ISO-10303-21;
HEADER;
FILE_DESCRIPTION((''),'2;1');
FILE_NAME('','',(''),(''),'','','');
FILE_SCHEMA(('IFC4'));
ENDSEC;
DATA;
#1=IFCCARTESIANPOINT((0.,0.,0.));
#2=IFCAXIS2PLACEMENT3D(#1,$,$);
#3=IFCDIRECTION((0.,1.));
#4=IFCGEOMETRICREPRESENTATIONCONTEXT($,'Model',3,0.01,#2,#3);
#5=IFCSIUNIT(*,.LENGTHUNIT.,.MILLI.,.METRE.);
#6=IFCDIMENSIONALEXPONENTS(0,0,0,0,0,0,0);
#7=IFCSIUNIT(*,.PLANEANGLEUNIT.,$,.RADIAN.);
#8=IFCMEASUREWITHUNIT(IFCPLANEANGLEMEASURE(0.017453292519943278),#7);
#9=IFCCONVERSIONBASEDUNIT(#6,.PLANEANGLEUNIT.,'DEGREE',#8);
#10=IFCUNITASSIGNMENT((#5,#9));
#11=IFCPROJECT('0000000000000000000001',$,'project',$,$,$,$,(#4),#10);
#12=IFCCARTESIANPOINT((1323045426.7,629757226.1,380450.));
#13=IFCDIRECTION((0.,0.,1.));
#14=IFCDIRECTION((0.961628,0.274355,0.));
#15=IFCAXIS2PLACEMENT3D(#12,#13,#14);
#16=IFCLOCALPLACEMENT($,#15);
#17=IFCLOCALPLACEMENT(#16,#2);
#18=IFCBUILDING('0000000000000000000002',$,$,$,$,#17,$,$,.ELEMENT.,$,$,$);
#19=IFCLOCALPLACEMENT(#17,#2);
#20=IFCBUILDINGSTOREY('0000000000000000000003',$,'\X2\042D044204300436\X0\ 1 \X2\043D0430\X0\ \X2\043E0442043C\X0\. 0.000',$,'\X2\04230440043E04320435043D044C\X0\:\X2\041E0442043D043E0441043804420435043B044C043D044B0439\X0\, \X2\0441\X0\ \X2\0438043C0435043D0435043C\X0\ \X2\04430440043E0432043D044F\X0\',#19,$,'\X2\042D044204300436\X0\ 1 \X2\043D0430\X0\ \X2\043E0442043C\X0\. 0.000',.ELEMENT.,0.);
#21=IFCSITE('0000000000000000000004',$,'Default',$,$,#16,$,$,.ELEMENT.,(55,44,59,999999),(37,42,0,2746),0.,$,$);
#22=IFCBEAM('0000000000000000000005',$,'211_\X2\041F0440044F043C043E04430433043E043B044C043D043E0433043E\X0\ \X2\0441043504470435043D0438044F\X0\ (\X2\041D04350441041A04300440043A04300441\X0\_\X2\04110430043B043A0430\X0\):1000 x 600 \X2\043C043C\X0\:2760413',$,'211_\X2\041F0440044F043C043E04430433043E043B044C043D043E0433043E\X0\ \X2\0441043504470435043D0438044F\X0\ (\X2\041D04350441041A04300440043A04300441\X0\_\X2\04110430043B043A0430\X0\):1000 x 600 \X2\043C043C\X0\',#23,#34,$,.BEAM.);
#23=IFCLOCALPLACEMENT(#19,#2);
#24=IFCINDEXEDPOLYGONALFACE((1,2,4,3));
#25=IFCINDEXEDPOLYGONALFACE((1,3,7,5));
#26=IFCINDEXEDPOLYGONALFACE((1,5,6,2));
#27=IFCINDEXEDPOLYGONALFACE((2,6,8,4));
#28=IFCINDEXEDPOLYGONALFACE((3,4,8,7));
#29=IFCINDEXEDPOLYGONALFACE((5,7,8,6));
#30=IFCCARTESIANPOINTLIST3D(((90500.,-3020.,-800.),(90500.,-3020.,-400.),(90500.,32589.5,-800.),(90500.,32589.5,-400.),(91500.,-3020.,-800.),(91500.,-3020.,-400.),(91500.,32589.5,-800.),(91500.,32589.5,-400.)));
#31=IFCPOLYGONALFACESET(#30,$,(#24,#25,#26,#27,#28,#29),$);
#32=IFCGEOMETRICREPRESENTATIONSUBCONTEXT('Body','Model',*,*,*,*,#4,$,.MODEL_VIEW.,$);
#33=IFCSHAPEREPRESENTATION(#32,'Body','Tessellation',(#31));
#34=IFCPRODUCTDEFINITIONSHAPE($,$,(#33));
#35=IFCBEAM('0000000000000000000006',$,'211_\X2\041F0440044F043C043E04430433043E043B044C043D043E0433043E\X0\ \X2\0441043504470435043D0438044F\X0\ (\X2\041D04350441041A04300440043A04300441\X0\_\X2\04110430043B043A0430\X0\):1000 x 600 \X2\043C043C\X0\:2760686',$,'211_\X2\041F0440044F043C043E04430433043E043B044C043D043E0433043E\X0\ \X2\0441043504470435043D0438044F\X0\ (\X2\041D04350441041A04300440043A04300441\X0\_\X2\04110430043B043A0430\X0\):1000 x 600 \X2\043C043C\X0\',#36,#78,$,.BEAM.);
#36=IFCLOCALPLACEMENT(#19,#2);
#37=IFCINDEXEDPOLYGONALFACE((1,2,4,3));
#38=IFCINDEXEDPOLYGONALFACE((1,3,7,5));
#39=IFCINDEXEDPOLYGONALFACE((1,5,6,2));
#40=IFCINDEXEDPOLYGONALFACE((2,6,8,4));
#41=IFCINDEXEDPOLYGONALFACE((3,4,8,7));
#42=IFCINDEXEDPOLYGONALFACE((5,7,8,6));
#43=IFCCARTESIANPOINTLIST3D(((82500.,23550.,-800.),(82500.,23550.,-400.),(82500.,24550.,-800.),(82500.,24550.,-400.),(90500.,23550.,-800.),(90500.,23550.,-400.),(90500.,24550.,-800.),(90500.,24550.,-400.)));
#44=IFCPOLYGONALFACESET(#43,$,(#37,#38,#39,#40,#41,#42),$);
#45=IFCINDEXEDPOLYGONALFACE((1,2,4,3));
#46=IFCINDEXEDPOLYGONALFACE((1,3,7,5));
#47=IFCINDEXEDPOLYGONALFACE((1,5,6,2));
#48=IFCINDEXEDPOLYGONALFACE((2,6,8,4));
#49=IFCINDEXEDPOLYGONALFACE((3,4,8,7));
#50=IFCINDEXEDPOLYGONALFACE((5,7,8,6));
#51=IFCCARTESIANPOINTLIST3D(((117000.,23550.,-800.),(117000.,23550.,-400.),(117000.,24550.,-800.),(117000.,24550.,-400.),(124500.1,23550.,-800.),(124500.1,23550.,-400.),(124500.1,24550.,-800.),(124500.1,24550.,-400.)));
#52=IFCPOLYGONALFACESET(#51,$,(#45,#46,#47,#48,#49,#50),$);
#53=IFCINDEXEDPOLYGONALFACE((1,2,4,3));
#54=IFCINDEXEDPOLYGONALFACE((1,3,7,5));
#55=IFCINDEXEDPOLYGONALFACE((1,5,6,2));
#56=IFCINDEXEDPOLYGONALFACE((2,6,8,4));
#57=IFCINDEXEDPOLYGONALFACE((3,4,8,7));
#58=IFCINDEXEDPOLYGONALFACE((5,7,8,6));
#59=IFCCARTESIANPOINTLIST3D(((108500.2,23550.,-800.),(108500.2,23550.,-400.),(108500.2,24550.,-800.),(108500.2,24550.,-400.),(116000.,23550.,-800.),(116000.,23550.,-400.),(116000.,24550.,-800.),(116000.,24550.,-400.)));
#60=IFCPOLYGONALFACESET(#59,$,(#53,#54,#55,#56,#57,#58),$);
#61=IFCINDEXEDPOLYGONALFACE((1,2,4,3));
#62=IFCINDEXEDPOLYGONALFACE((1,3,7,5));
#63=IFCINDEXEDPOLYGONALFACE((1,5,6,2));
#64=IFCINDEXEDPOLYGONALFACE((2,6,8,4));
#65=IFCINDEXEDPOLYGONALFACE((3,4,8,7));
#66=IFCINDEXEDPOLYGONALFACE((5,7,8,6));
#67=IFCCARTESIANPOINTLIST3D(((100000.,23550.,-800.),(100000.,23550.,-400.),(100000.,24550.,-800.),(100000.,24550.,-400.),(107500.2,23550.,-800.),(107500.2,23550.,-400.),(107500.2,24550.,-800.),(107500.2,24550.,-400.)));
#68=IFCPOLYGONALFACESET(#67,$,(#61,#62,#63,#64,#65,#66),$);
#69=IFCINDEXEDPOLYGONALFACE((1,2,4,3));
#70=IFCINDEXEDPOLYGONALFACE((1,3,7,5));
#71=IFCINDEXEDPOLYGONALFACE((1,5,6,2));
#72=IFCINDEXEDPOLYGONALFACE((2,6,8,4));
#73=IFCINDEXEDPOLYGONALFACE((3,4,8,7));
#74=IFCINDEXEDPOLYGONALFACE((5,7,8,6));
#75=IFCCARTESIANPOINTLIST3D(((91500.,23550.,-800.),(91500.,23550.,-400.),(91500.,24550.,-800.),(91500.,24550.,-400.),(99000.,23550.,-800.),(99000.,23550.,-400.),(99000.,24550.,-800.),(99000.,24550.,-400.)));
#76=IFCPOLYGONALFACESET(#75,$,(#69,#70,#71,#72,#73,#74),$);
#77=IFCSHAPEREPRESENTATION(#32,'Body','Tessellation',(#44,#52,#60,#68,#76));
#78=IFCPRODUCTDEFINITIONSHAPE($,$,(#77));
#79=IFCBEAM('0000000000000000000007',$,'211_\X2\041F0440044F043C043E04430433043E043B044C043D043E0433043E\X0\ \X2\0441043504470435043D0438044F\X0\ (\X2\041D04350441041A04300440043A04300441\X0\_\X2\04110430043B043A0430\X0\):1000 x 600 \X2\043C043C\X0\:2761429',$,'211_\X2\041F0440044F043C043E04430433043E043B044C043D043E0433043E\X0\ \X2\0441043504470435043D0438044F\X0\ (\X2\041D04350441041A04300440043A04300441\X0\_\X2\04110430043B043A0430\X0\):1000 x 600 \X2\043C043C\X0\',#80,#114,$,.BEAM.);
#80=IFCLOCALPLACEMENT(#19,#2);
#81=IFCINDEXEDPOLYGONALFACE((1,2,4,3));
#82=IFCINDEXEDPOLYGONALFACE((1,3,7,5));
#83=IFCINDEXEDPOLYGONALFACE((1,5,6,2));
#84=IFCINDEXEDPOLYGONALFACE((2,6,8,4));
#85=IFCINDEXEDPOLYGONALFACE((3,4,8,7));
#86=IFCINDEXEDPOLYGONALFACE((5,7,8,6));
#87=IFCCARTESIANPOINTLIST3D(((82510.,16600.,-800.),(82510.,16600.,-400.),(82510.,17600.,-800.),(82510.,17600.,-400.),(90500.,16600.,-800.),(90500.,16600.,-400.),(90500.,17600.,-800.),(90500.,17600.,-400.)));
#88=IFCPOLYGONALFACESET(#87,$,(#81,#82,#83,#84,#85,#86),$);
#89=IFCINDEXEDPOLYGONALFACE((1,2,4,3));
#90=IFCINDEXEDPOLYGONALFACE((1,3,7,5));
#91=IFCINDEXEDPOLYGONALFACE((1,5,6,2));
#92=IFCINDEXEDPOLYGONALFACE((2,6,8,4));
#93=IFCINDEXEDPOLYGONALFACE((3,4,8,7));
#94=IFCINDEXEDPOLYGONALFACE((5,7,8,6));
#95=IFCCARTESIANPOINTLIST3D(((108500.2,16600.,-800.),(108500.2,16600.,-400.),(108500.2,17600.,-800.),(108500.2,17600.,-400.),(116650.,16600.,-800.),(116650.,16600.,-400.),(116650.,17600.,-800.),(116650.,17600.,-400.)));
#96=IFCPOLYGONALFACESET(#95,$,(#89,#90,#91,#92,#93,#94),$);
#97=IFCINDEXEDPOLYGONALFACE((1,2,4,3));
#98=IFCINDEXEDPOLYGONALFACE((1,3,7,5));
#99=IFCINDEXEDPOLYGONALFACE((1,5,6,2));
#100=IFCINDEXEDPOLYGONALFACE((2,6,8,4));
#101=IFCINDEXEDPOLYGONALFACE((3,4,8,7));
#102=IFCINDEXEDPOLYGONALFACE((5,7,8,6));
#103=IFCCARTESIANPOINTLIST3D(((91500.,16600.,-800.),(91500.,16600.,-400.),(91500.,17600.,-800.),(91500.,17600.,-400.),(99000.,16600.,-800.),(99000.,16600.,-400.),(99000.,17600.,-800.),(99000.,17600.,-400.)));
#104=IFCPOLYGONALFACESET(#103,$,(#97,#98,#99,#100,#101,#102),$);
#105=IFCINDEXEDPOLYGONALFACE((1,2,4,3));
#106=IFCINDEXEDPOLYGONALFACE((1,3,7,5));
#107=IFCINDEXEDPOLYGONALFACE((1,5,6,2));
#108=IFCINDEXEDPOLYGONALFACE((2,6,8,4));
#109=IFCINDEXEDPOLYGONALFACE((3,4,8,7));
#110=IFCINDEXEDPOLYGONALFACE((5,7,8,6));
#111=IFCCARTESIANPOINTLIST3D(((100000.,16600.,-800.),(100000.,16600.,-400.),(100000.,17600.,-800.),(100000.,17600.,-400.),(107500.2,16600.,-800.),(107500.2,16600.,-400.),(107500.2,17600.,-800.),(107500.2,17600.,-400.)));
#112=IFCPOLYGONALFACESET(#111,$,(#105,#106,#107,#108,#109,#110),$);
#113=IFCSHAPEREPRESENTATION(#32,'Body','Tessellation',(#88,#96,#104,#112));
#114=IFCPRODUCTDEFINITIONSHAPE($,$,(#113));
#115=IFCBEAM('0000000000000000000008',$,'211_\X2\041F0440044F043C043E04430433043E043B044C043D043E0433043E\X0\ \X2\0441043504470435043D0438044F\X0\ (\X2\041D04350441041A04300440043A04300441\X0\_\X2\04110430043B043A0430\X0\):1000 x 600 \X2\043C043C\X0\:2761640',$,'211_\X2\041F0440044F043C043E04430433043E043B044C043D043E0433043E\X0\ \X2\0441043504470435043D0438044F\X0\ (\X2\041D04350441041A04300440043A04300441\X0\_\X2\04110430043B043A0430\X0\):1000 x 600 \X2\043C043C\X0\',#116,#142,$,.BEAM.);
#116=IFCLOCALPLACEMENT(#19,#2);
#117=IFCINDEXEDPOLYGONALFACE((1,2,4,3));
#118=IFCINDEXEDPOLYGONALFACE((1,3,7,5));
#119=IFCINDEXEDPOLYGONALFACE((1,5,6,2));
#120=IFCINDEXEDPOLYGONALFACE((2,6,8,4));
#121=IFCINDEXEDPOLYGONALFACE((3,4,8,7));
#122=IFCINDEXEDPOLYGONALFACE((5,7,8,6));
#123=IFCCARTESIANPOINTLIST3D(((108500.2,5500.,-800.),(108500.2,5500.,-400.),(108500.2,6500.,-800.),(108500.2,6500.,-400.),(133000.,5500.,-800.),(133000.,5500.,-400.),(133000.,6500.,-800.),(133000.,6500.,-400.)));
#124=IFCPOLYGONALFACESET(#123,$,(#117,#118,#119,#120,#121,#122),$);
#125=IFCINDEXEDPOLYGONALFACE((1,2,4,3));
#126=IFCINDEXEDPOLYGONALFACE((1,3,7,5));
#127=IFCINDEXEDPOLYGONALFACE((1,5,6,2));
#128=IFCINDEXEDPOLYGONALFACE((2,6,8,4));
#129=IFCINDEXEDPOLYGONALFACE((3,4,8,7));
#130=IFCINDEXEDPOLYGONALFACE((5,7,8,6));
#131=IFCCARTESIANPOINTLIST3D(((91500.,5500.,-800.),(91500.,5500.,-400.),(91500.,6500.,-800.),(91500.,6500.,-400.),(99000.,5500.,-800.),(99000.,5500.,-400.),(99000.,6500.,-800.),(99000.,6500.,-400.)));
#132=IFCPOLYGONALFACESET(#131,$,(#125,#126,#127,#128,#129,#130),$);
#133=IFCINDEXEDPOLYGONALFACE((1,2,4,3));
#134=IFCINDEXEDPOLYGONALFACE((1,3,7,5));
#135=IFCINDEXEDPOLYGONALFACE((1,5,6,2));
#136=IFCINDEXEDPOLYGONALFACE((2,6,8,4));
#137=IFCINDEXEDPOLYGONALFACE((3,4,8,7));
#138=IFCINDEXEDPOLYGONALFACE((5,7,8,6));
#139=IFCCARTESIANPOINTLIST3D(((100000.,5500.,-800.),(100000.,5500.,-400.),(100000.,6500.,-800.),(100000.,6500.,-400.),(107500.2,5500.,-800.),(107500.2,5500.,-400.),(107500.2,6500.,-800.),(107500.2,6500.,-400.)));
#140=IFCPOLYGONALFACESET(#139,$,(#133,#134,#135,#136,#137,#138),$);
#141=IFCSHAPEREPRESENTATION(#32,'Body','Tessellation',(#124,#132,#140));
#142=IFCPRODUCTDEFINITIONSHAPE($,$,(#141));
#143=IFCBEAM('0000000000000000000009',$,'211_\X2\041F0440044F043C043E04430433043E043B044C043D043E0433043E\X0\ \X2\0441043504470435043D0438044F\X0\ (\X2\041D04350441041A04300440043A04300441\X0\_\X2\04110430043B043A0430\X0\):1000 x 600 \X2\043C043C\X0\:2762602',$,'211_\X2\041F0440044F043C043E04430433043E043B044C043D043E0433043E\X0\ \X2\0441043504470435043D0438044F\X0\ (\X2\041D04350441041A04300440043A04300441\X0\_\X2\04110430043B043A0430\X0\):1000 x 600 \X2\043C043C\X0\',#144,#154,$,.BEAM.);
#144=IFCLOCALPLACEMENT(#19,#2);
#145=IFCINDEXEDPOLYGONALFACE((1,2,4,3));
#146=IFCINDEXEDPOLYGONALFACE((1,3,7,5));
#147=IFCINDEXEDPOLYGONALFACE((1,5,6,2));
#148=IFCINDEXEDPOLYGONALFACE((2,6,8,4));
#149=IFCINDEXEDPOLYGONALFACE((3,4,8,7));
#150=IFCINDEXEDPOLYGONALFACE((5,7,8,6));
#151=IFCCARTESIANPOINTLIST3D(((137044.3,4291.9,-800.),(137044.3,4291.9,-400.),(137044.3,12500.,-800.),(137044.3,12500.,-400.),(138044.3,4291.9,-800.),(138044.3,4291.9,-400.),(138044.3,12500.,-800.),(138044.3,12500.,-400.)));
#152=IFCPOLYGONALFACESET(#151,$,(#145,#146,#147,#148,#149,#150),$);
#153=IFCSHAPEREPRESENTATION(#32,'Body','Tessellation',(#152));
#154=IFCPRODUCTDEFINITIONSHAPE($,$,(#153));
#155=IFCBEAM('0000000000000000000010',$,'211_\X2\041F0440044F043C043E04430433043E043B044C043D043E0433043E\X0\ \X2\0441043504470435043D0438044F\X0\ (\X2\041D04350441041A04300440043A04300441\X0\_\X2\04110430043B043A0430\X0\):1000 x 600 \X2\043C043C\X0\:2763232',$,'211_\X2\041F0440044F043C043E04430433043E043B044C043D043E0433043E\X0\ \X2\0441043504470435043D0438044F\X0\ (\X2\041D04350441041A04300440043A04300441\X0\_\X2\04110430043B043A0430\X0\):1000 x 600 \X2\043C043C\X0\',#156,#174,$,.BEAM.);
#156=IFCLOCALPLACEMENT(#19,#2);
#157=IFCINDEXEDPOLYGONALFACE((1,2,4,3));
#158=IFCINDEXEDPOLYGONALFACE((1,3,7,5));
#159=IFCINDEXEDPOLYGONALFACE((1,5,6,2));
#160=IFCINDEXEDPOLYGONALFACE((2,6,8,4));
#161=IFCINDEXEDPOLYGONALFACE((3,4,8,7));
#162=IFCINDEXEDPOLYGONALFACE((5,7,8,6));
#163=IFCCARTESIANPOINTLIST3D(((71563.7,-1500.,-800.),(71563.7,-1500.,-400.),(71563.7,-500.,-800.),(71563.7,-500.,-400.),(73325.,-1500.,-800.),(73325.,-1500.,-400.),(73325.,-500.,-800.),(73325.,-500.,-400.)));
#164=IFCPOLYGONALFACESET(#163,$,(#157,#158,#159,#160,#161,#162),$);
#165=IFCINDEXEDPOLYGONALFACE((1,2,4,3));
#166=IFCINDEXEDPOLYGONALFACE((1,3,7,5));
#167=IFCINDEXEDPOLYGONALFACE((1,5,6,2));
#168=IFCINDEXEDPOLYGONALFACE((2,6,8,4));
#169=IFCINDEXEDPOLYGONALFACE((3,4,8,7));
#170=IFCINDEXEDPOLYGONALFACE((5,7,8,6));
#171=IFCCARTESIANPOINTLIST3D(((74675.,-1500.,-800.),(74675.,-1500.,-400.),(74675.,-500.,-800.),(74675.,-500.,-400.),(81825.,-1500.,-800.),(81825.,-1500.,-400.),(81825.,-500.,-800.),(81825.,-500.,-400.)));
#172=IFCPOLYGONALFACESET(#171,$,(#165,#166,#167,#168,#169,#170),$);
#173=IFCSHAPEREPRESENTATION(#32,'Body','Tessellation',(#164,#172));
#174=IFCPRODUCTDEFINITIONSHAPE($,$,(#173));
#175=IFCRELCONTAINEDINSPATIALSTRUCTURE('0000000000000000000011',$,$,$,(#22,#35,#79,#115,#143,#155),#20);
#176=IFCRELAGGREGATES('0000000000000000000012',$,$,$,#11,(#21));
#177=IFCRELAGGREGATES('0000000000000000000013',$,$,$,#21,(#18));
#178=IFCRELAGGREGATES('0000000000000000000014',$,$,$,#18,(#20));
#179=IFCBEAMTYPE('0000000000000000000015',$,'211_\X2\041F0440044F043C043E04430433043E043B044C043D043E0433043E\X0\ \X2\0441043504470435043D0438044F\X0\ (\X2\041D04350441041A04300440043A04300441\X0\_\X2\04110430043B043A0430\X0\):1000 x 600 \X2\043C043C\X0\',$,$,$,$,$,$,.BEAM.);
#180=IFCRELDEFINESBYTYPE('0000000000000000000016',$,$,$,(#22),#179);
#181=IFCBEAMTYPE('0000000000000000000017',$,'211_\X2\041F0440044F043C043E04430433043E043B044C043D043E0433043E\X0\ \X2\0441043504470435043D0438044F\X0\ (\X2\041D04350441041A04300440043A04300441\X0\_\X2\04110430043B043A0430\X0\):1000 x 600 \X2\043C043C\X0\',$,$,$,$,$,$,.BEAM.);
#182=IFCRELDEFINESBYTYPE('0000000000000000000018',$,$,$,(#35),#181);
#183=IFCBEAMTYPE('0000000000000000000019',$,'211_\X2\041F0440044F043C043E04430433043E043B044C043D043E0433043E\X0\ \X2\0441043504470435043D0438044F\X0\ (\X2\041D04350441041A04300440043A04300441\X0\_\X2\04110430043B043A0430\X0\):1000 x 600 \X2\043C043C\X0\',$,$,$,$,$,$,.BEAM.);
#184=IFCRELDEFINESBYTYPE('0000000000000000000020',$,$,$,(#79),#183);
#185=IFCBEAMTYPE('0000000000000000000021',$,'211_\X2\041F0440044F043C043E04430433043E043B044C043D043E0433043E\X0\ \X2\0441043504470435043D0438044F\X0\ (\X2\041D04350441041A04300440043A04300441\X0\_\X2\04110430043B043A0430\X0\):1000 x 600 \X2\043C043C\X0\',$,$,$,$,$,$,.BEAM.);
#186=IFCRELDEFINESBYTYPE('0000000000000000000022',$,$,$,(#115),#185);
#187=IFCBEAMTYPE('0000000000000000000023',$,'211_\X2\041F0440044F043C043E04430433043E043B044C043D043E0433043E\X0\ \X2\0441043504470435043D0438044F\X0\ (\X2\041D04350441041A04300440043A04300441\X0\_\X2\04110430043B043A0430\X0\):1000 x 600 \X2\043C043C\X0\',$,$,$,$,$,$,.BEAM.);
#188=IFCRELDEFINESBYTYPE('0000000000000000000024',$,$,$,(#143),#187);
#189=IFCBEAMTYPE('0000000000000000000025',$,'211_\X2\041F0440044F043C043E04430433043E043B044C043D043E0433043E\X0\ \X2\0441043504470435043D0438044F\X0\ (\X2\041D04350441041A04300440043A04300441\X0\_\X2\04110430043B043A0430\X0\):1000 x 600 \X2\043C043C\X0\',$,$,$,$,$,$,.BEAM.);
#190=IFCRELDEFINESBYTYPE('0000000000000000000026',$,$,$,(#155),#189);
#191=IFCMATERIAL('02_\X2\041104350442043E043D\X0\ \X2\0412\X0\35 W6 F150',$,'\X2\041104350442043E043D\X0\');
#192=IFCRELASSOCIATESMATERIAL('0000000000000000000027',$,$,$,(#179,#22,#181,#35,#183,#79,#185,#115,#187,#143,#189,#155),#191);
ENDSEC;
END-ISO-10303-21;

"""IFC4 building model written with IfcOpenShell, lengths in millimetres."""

from ifc_helpers import new_model, entity, si_unit, converted_unit, direction, frame, origin, place, context, subcontext, project, spatial, indexed_curve, outline, extrude, source, transform, mapped, material, type_object, type_shapes, element, save


model = new_model("IFC4")

# Units and contexts
model_context = context("Model", 3, precision=0.01, world=origin(), true_north=direction((0.0, 1.0)))
body_context = subcontext(model_context, "Body", "Model", "MODEL_VIEW")
ifc_project = project(units=[si_unit("LENGTHUNIT", "METRE", prefix="MILLI"), converted_unit("PLANEANGLEUNIT", "DEGREE", entity("IfcPlaneAngleMeasure", 0.017453292519943278), si_unit("PLANEANGLEUNIT", "RADIAN"), dimensions=[0, 0, 0, 0, 0, 0, 0])], contexts=[model_context])

# Site, building, storey
site_placement = place(None, frame((1323045426.7, 629757226.1, 380450.0), z_axis=(0.0, 0.0, 1.0), x_axis=(0.961628, 0.274355, 0.0)))
site = spatial("IfcSite", under=ifc_project, at=site_placement, Name="Default", CompositionType="ELEMENT", RefLatitude=(55, 44, 59, 999999), RefLongitude=(37, 42, 0, 2746), RefElevation=0.0)
building_placement = place(site_placement, origin())
building = spatial("IfcBuilding", under=site, at=building_placement, CompositionType="ELEMENT")
storey_placement = place(building_placement, origin())
storey = spatial("IfcBuildingStorey", under=building, at=storey_placement, Name="Этаж 1 на отм. 0.000", ObjectType="Уровень:Относительный, с именем уровня", LongName="Этаж 1 на отм. 0.000", CompositionType="ELEMENT", Elevation=0.0)

# Beams
ifc_material = material(Name="02_Бетон В35 W6 F150", Category="Бетон")
beam_type_1 = type_object("IfcBeamType", Name="211_Прямоугольного сечения (НесКаркас_Балка):1000 x 600 мм", PredefinedType="BEAM", material=ifc_material)
shared_shape_1 = source(origin(), body_context, "Body", "SweptSolid", [
    extrude(outline(indexed_curve([(-500.0, -200.0), (500.0, -200.0), (500.0, 200.0), (-500.0, 200.0), (-500.0, -200.0)], self_intersect=False)), frame((91000.0, 32589.5, -600.0), z_axis=(0.0, -1.0, 0.0), x_axis=(-1.0, 0.0, 0.0)), (0.0, 0.0, 1.0), 35609.5),
])
type_shapes(beam_type_1, [shared_shape_1])
beam_1_placement = place(storey_placement, origin())
element("IfcBeam", 1, at=beam_1_placement, inside=storey, type_object=beam_type_1, material=ifc_material, Name="211_Прямоугольного сечения (НесКаркас_Балка):1000 x 600 мм:2760413", ObjectType="211_Прямоугольного сечения (НесКаркас_Балка):1000 x 600 мм", PredefinedType="BEAM", context=body_context, shape_type="MappedRepresentation", body=[
    mapped(shared_shape_1, transform((0.0, 0.0, 0.0), scale=1.0)),
])
beam_type_2 = type_object("IfcBeamType", Name="211_Прямоугольного сечения (НесКаркас_Балка):1000 x 600 мм", PredefinedType="BEAM", material=ifc_material)
shared_shape_2 = source(origin(), body_context, "Body", "SweptSolid", [
    extrude(outline(indexed_curve([(-200.0, -500.0), (200.0, -500.0), (200.0, 500.0), (-200.0, 500.0), (-200.0, -500.0)], self_intersect=False)), frame((82500.0, 24050.0, -600.0), z_axis=(1.0, 0.0, 0.0), x_axis=(0.0, 0.0, -1.0)), (0.0, 0.0, 1.0), 8000.0),
    extrude(outline(indexed_curve([(-200.0, -500.0), (200.0, -500.0), (200.0, 500.0), (-200.0, 500.0), (-200.0, -500.0)], self_intersect=False)), frame((117000.0, 24050.0, -600.0), z_axis=(1.0, 0.0, 0.0), x_axis=(0.0, 0.0, -1.0)), (0.0, 0.0, 1.0), 7500.1),
    extrude(outline(indexed_curve([(-200.0, -500.0), (200.0, -500.0), (200.0, 500.0), (-200.0, 500.0), (-200.0, -500.0)], self_intersect=False)), frame((108500.2, 24050.0, -600.0), z_axis=(1.0, 0.0, 0.0), x_axis=(0.0, 0.0, -1.0)), (0.0, 0.0, 1.0), 7499.8),
    extrude(outline(indexed_curve([(-200.0, -500.0), (200.0, -500.0), (200.0, 500.0), (-200.0, 500.0), (-200.0, -500.0)], self_intersect=False)), frame((100000.0, 24050.0, -600.0), z_axis=(1.0, 0.0, 0.0), x_axis=(0.0, 0.0, -1.0)), (0.0, 0.0, 1.0), 7500.2),
    extrude(outline(indexed_curve([(-200.0, -500.0), (200.0, -500.0), (200.0, 500.0), (-200.0, 500.0), (-200.0, -500.0)], self_intersect=False)), frame((91500.0, 24050.0, -600.0), z_axis=(1.0, 0.0, 0.0), x_axis=(0.0, 0.0, -1.0)), (0.0, 0.0, 1.0), 7500.0),
])
type_shapes(beam_type_2, [shared_shape_2])
beam_2_placement = place(storey_placement, origin())
element("IfcBeam", 2, at=beam_2_placement, inside=storey, type_object=beam_type_2, material=ifc_material, Name="211_Прямоугольного сечения (НесКаркас_Балка):1000 x 600 мм:2760686", ObjectType="211_Прямоугольного сечения (НесКаркас_Балка):1000 x 600 мм", PredefinedType="BEAM", context=body_context, shape_type="MappedRepresentation", body=[
    mapped(shared_shape_2, transform((0.0, 0.0, 0.0), scale=1.0)),
])
beam_type_3 = type_object("IfcBeamType", Name="211_Прямоугольного сечения (НесКаркас_Балка):1000 x 600 мм", PredefinedType="BEAM", material=ifc_material)
shared_shape_3 = source(origin(), body_context, "Body", "SweptSolid", [
    extrude(outline(indexed_curve([(-200.0, -500.0), (200.0, -500.0), (200.0, 500.0), (-200.0, 500.0), (-200.0, -500.0)], self_intersect=False)), frame((82510.0, 17100.0, -600.0), z_axis=(1.0, 0.0, 0.0), x_axis=(0.0, 0.0, -1.0)), (0.0, 0.0, 1.0), 7990.0),
    extrude(outline(indexed_curve([(-200.0, -500.0), (200.0, -500.0), (200.0, 500.0), (-200.0, 500.0), (-200.0, -500.0)], self_intersect=False)), frame((108500.2, 17100.0, -600.0), z_axis=(1.0, 0.0, 0.0), x_axis=(0.0, 0.0, -1.0)), (0.0, 0.0, 1.0), 8149.8),
    extrude(outline(indexed_curve([(-200.0, -500.0), (200.0, -500.0), (200.0, 500.0), (-200.0, 500.0), (-200.0, -500.0)], self_intersect=False)), frame((91500.0, 17100.0, -600.0), z_axis=(1.0, 0.0, 0.0), x_axis=(0.0, 0.0, -1.0)), (0.0, 0.0, 1.0), 7500.0),
    extrude(outline(indexed_curve([(-200.0, -500.0), (200.0, -500.0), (200.0, 500.0), (-200.0, 500.0), (-200.0, -500.0)], self_intersect=False)), frame((100000.0, 17100.0, -600.0), z_axis=(1.0, 0.0, 0.0), x_axis=(0.0, 0.0, -1.0)), (0.0, 0.0, 1.0), 7500.2),
])
type_shapes(beam_type_3, [shared_shape_3])
beam_3_placement = place(storey_placement, origin())
element("IfcBeam", 3, at=beam_3_placement, inside=storey, type_object=beam_type_3, material=ifc_material, Name="211_Прямоугольного сечения (НесКаркас_Балка):1000 x 600 мм:2761429", ObjectType="211_Прямоугольного сечения (НесКаркас_Балка):1000 x 600 мм", PredefinedType="BEAM", context=body_context, shape_type="MappedRepresentation", body=[
    mapped(shared_shape_3, transform((0.0, 0.0, 0.0), scale=1.0)),
])
beam_type_4 = type_object("IfcBeamType", Name="211_Прямоугольного сечения (НесКаркас_Балка):1000 x 600 мм", PredefinedType="BEAM", material=ifc_material)
shared_shape_4 = source(origin(), body_context, "Body", "SweptSolid", [
    extrude(outline(indexed_curve([(-200.0, -500.0), (200.0, -500.0), (200.0, 500.0), (-200.0, 500.0), (-200.0, -500.0)], self_intersect=False)), frame((108500.2, 6000.0, -600.0), z_axis=(1.0, 0.0, 0.0), x_axis=(0.0, 0.0, -1.0)), (0.0, 0.0, 1.0), 24499.8),
    extrude(outline(indexed_curve([(-200.0, -500.0), (200.0, -500.0), (200.0, 500.0), (-200.0, 500.0), (-200.0, -500.0)], self_intersect=False)), frame((91500.0, 6000.0, -600.0), z_axis=(1.0, 0.0, 0.0), x_axis=(0.0, 0.0, -1.0)), (0.0, 0.0, 1.0), 7500.0),
    extrude(outline(indexed_curve([(-200.0, -500.0), (200.0, -500.0), (200.0, 500.0), (-200.0, 500.0), (-200.0, -500.0)], self_intersect=False)), frame((100000.0, 6000.0, -600.0), z_axis=(1.0, 0.0, 0.0), x_axis=(0.0, 0.0, -1.0)), (0.0, 0.0, 1.0), 7500.2),
])
type_shapes(beam_type_4, [shared_shape_4])
beam_4_placement = place(storey_placement, origin())
element("IfcBeam", 4, at=beam_4_placement, inside=storey, type_object=beam_type_4, material=ifc_material, Name="211_Прямоугольного сечения (НесКаркас_Балка):1000 x 600 мм:2761640", ObjectType="211_Прямоугольного сечения (НесКаркас_Балка):1000 x 600 мм", PredefinedType="BEAM", context=body_context, shape_type="MappedRepresentation", body=[
    mapped(shared_shape_4, transform((0.0, 0.0, 0.0), scale=1.0)),
])
beam_type_5 = type_object("IfcBeamType", Name="211_Прямоугольного сечения (НесКаркас_Балка):1000 x 600 мм", PredefinedType="BEAM", material=ifc_material)
shared_shape_5 = source(origin(), body_context, "Body", "SweptSolid", [
    extrude(outline(indexed_curve([(-500.0, -200.0), (500.0, -200.0), (500.0, 200.0), (-500.0, 200.0), (-500.0, -200.0)], self_intersect=False)), frame((137544.3, 12500.0, -600.0), z_axis=(0.0, -1.0, 0.0), x_axis=(-1.0, 0.0, 0.0)), (0.0, 0.0, 1.0), 8208.1),
])
type_shapes(beam_type_5, [shared_shape_5])
beam_5_placement = place(storey_placement, origin())
element("IfcBeam", 5, at=beam_5_placement, inside=storey, type_object=beam_type_5, material=ifc_material, Name="211_Прямоугольного сечения (НесКаркас_Балка):1000 x 600 мм:2762602", ObjectType="211_Прямоугольного сечения (НесКаркас_Балка):1000 x 600 мм", PredefinedType="BEAM", context=body_context, shape_type="MappedRepresentation", body=[
    mapped(shared_shape_5, transform((0.0, 0.0, 0.0), scale=1.0)),
])
beam_type_6 = type_object("IfcBeamType", Name="211_Прямоугольного сечения (НесКаркас_Балка):1000 x 600 мм", PredefinedType="BEAM", material=ifc_material)
shared_shape_6 = source(origin(), body_context, "Body", "SweptSolid", [
    extrude(outline(indexed_curve([(-200.0, -500.0), (200.0, -500.0), (200.0, 500.0), (-200.0, 500.0), (-200.0, -500.0)], self_intersect=False)), frame((73325.0, -1000.0, -600.0), z_axis=(-1.0, 0.0, 0.0), x_axis=(0.0, 0.0, -1.0)), (0.0, 0.0, 1.0), 1761.3),
    extrude(outline(indexed_curve([(-200.0, -500.0), (200.0, -500.0), (200.0, 500.0), (-200.0, 500.0), (-200.0, -500.0)], self_intersect=False)), frame((81825.0, -1000.0, -600.0), z_axis=(-1.0, 0.0, 0.0), x_axis=(0.0, 0.0, -1.0)), (0.0, 0.0, 1.0), 7150.0),
])
type_shapes(beam_type_6, [shared_shape_6])
beam_6_placement = place(storey_placement, origin())
element("IfcBeam", 6, at=beam_6_placement, inside=storey, type_object=beam_type_6, material=ifc_material, Name="211_Прямоугольного сечения (НесКаркас_Балка):1000 x 600 мм:2763232", ObjectType="211_Прямоугольного сечения (НесКаркас_Балка):1000 x 600 мм", PredefinedType="BEAM", context=body_context, shape_type="MappedRepresentation", body=[
    mapped(shared_shape_6, transform((0.0, 0.0, 0.0), scale=1.0)),
])

save(model, "model.ifc")
